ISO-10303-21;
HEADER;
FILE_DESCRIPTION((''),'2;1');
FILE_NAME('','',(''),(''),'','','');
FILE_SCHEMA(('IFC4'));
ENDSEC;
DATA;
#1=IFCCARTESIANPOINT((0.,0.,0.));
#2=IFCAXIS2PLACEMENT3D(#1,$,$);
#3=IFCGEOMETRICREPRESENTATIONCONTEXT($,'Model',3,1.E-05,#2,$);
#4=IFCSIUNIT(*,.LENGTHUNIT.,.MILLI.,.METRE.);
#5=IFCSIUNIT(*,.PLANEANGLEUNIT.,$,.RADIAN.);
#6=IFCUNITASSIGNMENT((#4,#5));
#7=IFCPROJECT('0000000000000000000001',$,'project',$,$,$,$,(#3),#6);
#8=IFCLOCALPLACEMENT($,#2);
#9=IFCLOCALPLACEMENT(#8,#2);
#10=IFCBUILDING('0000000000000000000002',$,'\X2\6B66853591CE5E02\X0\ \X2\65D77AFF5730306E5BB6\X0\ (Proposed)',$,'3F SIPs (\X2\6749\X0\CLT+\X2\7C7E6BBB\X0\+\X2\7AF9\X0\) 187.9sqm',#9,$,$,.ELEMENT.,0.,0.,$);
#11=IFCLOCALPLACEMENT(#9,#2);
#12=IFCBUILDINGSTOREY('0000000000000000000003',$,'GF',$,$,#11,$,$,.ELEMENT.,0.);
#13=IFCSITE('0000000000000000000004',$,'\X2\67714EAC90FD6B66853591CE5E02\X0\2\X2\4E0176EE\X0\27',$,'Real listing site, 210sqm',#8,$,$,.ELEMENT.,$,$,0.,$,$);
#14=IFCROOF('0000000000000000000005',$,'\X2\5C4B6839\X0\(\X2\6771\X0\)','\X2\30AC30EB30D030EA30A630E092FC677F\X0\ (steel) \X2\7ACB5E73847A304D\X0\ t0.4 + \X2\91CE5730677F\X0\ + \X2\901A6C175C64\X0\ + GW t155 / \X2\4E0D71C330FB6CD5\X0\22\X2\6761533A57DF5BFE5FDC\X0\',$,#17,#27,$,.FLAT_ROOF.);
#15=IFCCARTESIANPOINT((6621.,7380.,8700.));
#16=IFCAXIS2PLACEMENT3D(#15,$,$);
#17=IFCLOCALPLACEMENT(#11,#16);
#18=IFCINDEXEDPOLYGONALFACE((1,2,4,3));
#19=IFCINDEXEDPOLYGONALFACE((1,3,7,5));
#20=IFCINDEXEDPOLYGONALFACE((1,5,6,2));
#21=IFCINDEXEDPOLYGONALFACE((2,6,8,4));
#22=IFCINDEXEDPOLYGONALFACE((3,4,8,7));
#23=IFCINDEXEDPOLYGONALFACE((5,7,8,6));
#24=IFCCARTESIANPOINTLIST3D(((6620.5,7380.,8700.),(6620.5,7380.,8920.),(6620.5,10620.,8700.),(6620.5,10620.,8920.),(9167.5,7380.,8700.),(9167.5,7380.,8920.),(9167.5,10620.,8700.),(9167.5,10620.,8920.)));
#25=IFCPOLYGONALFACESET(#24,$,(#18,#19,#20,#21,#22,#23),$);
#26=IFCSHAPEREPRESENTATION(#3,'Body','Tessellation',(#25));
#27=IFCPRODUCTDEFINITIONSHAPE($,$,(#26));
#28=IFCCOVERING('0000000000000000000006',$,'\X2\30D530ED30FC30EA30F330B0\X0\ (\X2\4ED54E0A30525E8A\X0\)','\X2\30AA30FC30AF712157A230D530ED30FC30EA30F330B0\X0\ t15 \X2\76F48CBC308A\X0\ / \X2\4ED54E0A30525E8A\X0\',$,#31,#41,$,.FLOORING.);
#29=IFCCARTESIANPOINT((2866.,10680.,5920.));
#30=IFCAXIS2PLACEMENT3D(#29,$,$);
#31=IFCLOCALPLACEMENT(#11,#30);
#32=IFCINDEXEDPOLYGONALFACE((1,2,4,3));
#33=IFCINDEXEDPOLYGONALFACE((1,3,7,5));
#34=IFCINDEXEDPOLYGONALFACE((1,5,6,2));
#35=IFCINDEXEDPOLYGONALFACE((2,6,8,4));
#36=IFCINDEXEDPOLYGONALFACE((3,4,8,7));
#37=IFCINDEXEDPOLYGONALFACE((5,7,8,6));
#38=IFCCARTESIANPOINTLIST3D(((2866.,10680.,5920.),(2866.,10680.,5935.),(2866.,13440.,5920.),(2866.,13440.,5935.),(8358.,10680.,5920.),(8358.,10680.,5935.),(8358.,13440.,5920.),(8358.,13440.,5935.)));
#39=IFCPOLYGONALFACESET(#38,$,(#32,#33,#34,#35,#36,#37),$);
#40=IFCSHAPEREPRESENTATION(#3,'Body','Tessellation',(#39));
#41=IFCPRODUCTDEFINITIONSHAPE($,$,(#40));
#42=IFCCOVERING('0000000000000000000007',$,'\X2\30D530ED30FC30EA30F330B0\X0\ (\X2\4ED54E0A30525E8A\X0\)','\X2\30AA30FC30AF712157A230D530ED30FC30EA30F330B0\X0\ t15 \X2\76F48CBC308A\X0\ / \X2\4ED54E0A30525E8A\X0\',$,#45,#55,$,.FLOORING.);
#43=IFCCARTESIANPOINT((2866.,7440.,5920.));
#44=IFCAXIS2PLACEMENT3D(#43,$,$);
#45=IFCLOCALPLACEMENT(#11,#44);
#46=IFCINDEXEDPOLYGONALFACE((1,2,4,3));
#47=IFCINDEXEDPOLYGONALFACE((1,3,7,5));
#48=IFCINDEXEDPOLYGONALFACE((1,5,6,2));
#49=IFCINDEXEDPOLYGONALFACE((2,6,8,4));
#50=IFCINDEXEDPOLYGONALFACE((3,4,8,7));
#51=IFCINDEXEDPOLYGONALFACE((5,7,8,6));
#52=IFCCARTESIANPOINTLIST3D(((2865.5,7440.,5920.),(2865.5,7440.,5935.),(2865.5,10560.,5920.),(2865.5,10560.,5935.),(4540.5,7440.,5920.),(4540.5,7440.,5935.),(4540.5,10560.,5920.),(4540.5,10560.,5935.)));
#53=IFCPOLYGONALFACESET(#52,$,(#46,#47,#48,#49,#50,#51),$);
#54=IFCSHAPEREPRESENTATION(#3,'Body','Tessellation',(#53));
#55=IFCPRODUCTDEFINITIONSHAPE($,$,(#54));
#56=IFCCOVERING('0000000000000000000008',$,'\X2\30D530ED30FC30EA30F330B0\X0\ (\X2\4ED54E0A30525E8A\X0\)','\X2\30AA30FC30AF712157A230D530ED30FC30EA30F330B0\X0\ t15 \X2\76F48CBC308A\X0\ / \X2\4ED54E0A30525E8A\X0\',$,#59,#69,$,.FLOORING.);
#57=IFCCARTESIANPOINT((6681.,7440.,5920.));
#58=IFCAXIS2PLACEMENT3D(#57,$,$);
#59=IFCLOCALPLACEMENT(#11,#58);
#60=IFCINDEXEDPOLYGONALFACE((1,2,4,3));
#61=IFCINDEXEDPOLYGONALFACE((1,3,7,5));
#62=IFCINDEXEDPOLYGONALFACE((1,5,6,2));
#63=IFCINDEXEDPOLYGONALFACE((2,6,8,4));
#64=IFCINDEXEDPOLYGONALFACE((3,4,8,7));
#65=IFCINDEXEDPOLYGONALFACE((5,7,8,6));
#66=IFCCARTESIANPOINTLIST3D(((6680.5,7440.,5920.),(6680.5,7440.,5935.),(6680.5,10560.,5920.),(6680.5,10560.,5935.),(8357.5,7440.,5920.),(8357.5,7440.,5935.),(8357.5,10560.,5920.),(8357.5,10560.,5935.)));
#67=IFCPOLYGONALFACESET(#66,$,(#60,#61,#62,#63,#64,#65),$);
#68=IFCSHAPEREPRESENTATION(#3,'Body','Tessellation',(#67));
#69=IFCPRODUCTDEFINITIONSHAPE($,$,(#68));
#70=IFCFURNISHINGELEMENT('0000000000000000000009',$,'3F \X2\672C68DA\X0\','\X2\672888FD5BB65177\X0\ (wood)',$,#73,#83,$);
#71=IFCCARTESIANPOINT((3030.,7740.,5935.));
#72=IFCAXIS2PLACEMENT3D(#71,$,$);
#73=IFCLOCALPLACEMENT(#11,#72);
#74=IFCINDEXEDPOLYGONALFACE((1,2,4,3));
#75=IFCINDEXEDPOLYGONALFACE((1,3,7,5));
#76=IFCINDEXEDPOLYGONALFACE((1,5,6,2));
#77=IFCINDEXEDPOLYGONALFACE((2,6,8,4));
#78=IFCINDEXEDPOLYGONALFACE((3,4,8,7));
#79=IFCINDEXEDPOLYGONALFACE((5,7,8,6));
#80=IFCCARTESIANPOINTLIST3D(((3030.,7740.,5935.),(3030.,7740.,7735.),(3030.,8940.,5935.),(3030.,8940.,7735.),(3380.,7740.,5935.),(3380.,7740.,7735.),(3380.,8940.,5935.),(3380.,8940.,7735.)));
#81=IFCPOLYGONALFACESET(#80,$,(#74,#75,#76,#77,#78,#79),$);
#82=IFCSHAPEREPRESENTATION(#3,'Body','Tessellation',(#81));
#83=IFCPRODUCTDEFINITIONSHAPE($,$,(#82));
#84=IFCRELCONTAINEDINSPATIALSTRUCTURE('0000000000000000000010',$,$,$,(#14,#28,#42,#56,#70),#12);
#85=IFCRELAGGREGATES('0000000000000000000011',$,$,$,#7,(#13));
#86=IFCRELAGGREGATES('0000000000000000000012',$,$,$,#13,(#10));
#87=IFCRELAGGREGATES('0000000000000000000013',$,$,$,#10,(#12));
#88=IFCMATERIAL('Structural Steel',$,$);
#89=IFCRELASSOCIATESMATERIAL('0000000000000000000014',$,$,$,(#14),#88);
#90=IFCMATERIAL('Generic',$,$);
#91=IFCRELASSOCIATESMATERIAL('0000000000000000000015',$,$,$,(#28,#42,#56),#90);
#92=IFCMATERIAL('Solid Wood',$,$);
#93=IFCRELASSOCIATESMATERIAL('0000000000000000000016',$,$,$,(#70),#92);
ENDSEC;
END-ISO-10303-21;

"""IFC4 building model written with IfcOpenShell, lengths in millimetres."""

from ifc_helpers import new_model, si_unit, frame, frame_2d, origin, place, context, project, spatial, rectangle, extrude, material, element, save


model = new_model("IFC4")

# Units and contexts
model_context = context("Model", 3, precision=1e-05, world=origin())
ifc_project = project(units=[si_unit("LENGTHUNIT", "METRE", prefix="MILLI"), si_unit("PLANEANGLEUNIT", "RADIAN")], contexts=[model_context])

# Site, building, storey
site_placement = place(None, origin())
site = spatial("IfcSite", under=ifc_project, at=site_placement, Name="東京都武蔵野市2丁目27", ObjectType="Real listing site, 210sqm", CompositionType="ELEMENT", RefElevation=0.0)
building_placement = place(site_placement, origin())
building = spatial("IfcBuilding", under=site, at=building_placement, Name="武蔵野市 旗竿地の家 (Proposed)", ObjectType="3F SIPs (杉CLT+籾殻+竹) 187.9sqm", CompositionType="ELEMENT", ElevationOfRefHeight=0.0, ElevationOfTerrain=0.0)
storey_placement = place(building_placement, origin())
storey = spatial("IfcBuildingStorey", under=building, at=storey_placement, Name="GF", CompositionType="ELEMENT", Elevation=0.0)

# Shared definitions
ifc_material_1 = material(Name="Solid Wood")

# Shared definitions
ifc_material_2 = material(Name="Generic")

# Roof
ifc_material_3 = material(Name="Structural Steel")
roof_1_placement = place(storey_placement, frame((6621.0, 7380.0, 8700.0)))
element("IfcRoof", 1, at=roof_1_placement, inside=storey, material=ifc_material_3, Name="屋根(東)", Description="ガルバリウム鋼板 (steel) 立平葺き t0.4 + 野地板 + 通気層 + GW t155 / 不燃・法22条区域対応", PredefinedType="FLAT_ROOF", context=model_context, shape_type="SweptSolid", body=[
    extrude(rectangle(XDim=2547.0, YDim=3240.0, at=frame_2d((1273.0, 1620.0))), frame((6621.0, 7380.0, 8700.0)), (0.0, 0.0, 1.0), 220.0),
])

# Coverings
covering_1_placement = place(storey_placement, frame((2866.0, 10680.0, 5920.0)))
element("IfcCovering", 2, at=covering_1_placement, inside=storey, material=ifc_material_2, Name="フローリング (仕上げ床)", Description="オーク無垢フローリング t15 直貼り / 仕上げ床", PredefinedType="FLOORING", context=model_context, shape_type="SweptSolid", body=[
    extrude(rectangle(XDim=5492.0, YDim=2760.0, at=frame_2d((2746.0, 1380.0))), frame((2866.0, 10680.0, 5920.0)), (0.0, 0.0, 1.0), 15.0),
])
covering_2_placement = place(storey_placement, frame((2866.0, 7440.0, 5920.0)))
element("IfcCovering", 3, at=covering_2_placement, inside=storey, material=ifc_material_2, Name="フローリング (仕上げ床)", Description="オーク無垢フローリング t15 直貼り / 仕上げ床", PredefinedType="FLOORING", context=model_context, shape_type="SweptSolid", body=[
    extrude(rectangle(XDim=1675.0, YDim=3120.0, at=frame_2d((837.0, 1560.0))), frame((2866.0, 7440.0, 5920.0)), (0.0, 0.0, 1.0), 15.0),
])
covering_3_placement = place(storey_placement, frame((6681.0, 7440.0, 5920.0)))
element("IfcCovering", 4, at=covering_3_placement, inside=storey, material=ifc_material_2, Name="フローリング (仕上げ床)", Description="オーク無垢フローリング t15 直貼り / 仕上げ床", PredefinedType="FLOORING", context=model_context, shape_type="SweptSolid", body=[
    extrude(rectangle(XDim=1677.0, YDim=3120.0, at=frame_2d((838.0, 1560.0))), frame((6681.0, 7440.0, 5920.0)), (0.0, 0.0, 1.0), 15.0),
])

# Furnishing element
furnishing_placement = place(storey_placement, frame((3030.0, 7740.0, 5935.0)))
element("IfcFurnishingElement", 5, at=furnishing_placement, inside=storey, material=ifc_material_1, Name="3F 本棚", Description="木製家具 (wood)", context=model_context, shape_type="SweptSolid", body=[
    extrude(rectangle(XDim=350.0, YDim=1200.0, at=frame_2d((175.0, 600.0))), frame((3030.0, 7740.0, 5935.0)), (0.0, 0.0, 1.0), 1800.0),
])

save(model, "model.ifc")
